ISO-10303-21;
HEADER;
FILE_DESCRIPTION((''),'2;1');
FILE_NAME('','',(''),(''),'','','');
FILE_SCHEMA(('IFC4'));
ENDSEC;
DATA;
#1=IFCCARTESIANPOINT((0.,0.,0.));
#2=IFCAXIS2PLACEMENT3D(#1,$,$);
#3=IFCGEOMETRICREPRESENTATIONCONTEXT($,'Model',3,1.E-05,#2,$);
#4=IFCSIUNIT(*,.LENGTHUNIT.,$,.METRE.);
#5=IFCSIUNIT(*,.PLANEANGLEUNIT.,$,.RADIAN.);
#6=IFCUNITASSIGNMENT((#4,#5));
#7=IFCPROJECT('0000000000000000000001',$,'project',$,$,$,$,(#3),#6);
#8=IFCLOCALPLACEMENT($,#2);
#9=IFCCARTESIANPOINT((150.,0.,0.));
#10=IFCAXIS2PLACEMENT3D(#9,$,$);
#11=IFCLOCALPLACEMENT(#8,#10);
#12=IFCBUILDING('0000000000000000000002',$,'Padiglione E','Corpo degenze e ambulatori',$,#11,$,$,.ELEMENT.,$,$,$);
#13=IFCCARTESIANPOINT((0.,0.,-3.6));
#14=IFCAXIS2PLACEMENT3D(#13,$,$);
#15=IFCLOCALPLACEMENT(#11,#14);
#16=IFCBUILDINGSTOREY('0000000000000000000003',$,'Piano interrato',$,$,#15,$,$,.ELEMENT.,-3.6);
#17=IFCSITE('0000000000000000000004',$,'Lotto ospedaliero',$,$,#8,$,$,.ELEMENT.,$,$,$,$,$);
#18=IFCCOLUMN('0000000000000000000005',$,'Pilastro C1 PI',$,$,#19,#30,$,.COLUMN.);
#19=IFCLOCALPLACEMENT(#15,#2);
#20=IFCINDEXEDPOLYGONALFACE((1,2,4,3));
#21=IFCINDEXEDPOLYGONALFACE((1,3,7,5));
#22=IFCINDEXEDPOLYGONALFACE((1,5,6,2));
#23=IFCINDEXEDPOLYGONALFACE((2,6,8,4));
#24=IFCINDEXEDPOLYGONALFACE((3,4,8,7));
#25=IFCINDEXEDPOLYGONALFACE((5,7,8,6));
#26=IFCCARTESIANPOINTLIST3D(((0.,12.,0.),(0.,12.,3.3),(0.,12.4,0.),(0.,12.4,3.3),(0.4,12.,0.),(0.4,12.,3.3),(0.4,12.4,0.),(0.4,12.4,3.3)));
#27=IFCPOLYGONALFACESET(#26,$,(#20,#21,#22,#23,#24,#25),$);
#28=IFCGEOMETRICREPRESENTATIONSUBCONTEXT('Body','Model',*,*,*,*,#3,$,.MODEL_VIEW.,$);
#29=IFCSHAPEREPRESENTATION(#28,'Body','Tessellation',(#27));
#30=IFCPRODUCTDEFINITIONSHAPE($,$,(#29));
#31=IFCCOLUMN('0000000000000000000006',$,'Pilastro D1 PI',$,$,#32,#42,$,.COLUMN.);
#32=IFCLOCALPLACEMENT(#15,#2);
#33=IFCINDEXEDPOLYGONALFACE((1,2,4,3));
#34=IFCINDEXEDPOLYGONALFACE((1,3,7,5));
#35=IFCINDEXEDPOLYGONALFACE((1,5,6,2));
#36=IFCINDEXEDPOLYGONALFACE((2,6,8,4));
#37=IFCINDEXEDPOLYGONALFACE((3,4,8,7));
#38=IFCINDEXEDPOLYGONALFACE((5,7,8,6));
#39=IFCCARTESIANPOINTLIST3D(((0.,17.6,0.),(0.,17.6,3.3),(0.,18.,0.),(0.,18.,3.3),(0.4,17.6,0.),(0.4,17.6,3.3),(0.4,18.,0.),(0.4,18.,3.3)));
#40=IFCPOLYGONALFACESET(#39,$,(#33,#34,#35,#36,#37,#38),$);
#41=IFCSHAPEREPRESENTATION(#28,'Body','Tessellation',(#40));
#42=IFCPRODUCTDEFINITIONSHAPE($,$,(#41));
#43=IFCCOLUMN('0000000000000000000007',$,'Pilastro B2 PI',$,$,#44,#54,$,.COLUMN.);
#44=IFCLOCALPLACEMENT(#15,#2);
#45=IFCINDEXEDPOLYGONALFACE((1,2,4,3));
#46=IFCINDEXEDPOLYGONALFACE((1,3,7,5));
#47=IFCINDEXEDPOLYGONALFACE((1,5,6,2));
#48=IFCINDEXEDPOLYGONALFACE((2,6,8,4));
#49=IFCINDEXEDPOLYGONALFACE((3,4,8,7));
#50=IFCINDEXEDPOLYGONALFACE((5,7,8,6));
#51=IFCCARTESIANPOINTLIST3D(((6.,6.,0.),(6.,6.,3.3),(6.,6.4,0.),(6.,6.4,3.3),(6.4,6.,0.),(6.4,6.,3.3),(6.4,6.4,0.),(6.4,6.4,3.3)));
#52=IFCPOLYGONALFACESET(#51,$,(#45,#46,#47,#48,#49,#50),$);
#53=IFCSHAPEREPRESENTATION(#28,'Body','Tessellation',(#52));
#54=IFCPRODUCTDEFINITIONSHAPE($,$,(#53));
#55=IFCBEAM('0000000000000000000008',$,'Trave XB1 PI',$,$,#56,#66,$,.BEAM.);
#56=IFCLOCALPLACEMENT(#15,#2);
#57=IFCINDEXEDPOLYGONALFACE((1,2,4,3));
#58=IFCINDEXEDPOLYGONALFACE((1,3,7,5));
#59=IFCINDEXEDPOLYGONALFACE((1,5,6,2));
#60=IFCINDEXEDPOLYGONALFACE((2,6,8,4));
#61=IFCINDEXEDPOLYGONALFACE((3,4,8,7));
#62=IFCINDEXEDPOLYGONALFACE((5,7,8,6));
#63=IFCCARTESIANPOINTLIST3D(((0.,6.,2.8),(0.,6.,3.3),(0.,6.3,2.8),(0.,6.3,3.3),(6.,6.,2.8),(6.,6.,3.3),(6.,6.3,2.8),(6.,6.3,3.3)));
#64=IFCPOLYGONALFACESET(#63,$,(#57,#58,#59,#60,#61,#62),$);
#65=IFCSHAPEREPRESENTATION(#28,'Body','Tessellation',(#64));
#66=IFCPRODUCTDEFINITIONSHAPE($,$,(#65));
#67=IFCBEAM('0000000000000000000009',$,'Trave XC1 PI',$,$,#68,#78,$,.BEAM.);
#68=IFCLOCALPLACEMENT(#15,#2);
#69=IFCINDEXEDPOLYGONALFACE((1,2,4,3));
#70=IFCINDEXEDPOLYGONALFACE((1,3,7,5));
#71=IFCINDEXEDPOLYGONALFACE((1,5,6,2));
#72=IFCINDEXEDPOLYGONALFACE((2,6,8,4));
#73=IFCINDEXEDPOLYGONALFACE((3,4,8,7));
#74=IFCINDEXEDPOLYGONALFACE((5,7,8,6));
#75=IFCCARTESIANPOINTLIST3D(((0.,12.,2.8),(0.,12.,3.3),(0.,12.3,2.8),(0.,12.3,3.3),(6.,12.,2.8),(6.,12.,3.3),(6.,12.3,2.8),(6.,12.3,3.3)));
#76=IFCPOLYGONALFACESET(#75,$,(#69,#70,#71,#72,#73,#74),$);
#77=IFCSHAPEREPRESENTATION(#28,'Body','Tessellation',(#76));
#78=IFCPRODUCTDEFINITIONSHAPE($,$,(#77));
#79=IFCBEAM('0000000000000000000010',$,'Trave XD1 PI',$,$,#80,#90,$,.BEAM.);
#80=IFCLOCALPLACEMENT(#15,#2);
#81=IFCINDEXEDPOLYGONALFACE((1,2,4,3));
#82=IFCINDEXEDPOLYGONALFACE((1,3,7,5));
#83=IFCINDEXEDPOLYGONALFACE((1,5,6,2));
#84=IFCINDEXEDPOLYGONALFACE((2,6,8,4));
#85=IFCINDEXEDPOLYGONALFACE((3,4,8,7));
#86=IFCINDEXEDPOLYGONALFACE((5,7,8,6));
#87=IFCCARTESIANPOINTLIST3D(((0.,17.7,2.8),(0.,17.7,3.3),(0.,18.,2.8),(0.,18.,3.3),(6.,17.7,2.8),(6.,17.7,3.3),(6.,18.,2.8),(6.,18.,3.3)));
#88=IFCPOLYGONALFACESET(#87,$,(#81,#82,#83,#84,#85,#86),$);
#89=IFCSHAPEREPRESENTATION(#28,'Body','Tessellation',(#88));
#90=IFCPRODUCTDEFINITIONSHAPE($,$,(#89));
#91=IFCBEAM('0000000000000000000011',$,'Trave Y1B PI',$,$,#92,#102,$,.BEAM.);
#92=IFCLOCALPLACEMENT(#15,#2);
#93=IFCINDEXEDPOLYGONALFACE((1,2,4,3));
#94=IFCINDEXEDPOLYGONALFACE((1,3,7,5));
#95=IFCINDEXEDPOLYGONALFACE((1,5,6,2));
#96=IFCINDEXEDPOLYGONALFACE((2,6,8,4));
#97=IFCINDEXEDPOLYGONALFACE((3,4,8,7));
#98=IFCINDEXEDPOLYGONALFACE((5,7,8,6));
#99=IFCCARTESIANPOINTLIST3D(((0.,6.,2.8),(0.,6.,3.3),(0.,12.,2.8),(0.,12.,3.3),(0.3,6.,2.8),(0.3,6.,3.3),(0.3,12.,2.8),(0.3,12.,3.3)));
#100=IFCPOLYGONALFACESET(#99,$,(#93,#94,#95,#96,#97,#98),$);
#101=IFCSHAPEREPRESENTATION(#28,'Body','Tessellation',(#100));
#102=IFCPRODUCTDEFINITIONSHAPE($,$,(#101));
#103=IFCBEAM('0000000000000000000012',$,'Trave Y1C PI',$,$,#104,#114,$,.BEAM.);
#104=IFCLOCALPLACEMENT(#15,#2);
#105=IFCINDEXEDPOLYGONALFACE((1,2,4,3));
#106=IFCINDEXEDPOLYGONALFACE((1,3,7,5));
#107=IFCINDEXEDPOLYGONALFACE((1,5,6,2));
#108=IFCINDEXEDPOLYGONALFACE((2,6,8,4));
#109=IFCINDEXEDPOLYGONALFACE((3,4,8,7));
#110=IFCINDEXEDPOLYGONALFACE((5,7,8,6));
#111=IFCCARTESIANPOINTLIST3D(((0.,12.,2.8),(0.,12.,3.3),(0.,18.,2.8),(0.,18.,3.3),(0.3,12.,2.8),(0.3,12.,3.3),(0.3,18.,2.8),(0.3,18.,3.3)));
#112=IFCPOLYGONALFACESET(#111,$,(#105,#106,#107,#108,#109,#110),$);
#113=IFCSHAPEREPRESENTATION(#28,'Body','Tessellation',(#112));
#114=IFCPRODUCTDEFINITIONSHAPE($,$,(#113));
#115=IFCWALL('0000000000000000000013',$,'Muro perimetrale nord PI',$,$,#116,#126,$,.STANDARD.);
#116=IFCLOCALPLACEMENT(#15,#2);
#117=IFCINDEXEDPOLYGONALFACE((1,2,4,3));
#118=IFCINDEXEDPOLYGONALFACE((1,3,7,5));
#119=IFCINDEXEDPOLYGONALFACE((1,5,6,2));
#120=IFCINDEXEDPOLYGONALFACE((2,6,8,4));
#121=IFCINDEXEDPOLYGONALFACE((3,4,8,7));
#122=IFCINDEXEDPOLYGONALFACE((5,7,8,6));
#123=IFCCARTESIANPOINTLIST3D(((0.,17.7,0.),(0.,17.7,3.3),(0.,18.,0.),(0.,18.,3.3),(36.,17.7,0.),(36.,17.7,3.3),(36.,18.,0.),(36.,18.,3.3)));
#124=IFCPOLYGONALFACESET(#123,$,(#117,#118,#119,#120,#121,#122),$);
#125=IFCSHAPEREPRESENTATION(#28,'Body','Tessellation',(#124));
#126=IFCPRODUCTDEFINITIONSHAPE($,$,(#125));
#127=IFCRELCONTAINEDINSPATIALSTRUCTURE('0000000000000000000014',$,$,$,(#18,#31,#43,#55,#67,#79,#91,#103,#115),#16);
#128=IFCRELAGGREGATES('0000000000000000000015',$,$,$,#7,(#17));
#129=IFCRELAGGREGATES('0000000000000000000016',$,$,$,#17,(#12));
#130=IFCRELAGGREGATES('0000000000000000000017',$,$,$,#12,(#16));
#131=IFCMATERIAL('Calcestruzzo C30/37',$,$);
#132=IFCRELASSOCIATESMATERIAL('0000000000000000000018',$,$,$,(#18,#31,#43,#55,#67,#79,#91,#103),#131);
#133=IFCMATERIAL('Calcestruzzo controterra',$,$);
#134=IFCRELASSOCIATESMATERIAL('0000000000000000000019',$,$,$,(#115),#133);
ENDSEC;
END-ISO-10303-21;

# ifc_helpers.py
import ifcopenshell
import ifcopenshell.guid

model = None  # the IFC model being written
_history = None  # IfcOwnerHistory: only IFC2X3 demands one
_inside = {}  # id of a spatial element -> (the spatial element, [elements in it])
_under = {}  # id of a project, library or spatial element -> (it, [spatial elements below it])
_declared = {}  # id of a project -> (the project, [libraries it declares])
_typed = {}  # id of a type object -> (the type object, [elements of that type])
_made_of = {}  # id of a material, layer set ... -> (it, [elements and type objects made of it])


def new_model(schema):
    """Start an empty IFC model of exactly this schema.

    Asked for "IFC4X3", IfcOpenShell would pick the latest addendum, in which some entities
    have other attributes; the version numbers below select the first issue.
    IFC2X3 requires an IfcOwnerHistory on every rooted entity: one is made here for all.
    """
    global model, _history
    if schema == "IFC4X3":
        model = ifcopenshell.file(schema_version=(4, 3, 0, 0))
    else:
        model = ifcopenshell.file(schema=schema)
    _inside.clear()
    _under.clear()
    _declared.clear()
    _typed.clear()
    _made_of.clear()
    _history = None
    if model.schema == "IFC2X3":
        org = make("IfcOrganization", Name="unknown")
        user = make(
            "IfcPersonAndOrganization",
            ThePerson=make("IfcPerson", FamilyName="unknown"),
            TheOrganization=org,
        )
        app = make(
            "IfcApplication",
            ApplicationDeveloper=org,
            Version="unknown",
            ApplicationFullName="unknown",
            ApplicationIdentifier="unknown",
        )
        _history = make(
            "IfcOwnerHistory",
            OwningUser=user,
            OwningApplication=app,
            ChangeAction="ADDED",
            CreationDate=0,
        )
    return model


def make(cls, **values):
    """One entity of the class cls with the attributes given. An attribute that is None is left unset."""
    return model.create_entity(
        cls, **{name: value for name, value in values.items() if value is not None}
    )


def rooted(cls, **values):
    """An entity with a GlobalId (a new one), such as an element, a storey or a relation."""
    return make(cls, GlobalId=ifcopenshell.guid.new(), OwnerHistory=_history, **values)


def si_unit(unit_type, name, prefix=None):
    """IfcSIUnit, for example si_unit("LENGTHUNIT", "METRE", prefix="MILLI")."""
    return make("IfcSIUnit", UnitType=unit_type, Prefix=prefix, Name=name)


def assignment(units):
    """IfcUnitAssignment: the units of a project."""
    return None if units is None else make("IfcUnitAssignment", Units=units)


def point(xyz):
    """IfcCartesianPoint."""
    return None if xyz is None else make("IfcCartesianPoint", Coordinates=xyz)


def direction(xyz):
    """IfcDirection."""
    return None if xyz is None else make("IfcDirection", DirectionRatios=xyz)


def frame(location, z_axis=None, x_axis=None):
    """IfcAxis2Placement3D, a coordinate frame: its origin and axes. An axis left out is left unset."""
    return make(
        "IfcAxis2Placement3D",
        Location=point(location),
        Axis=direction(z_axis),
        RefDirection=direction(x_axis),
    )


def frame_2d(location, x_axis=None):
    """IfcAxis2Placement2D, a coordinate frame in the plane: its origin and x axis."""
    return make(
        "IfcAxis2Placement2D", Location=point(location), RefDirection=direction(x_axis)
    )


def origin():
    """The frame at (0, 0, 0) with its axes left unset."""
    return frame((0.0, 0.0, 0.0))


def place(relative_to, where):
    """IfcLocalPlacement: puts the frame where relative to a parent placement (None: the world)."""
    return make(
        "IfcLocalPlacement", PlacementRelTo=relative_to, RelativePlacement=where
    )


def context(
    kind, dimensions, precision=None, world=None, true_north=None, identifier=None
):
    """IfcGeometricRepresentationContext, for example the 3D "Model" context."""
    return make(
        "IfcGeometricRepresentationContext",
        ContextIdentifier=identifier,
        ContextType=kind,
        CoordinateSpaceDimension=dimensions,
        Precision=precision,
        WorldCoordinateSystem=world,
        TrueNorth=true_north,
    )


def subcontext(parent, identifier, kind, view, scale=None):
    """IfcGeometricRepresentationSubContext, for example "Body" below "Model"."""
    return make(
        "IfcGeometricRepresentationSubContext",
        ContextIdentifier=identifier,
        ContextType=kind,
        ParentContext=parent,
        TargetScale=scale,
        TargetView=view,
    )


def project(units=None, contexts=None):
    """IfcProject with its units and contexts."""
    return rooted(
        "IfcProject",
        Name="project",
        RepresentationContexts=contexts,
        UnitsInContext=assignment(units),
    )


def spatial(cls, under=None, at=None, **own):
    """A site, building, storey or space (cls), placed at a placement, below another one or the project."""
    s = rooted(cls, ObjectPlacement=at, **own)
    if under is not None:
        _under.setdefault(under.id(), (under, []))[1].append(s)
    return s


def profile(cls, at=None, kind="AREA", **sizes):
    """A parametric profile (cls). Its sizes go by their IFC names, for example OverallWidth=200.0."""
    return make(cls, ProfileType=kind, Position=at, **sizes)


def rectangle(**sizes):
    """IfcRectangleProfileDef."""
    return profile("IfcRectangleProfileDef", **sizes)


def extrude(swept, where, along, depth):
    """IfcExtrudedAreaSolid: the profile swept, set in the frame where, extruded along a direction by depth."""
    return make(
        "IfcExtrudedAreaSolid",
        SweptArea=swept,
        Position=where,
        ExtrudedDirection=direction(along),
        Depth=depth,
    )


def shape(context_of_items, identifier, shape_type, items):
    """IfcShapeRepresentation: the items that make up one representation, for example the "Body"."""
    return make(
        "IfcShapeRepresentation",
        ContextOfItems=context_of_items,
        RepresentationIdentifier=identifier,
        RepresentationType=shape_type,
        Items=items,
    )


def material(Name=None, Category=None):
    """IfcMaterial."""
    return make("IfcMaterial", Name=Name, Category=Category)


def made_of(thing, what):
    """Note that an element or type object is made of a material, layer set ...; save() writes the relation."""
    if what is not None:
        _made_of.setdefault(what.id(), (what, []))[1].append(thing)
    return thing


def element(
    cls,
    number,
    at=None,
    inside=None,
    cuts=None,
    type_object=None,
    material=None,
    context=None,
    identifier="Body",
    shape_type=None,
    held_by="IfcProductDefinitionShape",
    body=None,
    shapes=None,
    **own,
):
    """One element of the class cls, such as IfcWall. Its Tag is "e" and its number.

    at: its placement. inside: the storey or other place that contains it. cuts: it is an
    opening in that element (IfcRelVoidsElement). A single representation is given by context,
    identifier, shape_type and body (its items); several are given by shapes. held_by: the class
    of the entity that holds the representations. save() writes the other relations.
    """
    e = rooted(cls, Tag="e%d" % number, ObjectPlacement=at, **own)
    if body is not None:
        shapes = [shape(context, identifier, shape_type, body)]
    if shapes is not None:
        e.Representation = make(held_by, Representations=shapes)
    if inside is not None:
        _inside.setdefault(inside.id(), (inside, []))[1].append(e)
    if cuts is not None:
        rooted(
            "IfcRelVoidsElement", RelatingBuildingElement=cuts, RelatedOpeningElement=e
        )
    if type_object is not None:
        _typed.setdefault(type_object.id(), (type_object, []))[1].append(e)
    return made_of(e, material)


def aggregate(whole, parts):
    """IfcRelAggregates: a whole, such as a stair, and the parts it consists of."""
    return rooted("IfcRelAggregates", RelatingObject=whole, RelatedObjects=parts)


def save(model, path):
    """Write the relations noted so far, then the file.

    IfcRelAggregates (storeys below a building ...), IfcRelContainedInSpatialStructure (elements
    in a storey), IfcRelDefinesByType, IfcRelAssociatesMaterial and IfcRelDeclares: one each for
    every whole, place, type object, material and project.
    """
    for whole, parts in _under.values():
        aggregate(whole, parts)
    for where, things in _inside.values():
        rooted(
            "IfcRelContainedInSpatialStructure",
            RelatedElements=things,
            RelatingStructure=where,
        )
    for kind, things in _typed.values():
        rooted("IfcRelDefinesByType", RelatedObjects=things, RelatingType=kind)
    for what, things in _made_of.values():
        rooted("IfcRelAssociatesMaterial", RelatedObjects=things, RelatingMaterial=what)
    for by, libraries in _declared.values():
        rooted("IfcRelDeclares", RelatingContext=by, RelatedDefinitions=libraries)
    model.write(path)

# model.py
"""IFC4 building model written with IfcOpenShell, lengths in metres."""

from ifc_helpers import new_model, si_unit, frame, frame_2d, origin, place, context, subcontext, project, spatial, rectangle, extrude, material, element, save


model = new_model("IFC4")

# Units and contexts
model_context = context("Model", 3, precision=1e-05, world=origin())
body_context = subcontext(model_context, "Body", "Model", "MODEL_VIEW")
ifc_project = project(units=[si_unit("LENGTHUNIT", "METRE"), si_unit("PLANEANGLEUNIT", "RADIAN")], contexts=[model_context])

# Site, building, storey
site_placement = place(None, origin())
site = spatial("IfcSite", under=ifc_project, at=site_placement, Name="Lotto ospedaliero", CompositionType="ELEMENT")
building_placement = place(site_placement, frame((150.0, 0.0, 0.0)))
building = spatial("IfcBuilding", under=site, at=building_placement, Name="Padiglione E", Description="Corpo degenze e ambulatori", CompositionType="ELEMENT")
storey_placement = place(building_placement, frame((0.0, 0.0, -3.6)))
storey = spatial("IfcBuildingStorey", under=building, at=storey_placement, Name="Piano interrato", CompositionType="ELEMENT", Elevation=-3.6)

# Columns
ifc_material_1 = material(Name="Calcestruzzo C30/37")
for number, where, name in (
    (1, (0.0, 12.0, 0.0), "Pilastro C1 PI"),
    (2, (0.0, 17.6, 0.0), "Pilastro D1 PI"),
    (3, (6.0, 6.0, 0.0), "Pilastro B2 PI"),
):
    element("IfcColumn", number, at=place(storey_placement, frame(where)), inside=storey, material=ifc_material_1, Name=name, PredefinedType="COLUMN", context=body_context, shape_type="SweptSolid", body=[
        extrude(rectangle(XDim=0.4, YDim=0.4, at=frame_2d((0.2, 0.2))), origin(), (0.0, 0.0, 1.0), 3.3),
    ])

# Beams
for number, where, name in (
    (4, (0.0, 6.0, 2.8), "Trave XB1 PI"),
    (5, (0.0, 12.0, 2.8), "Trave XC1 PI"),
    (6, (0.0, 17.7, 2.8), "Trave XD1 PI"),
):
    element("IfcBeam", number, at=place(storey_placement, frame(where)), inside=storey, material=ifc_material_1, Name=name, PredefinedType="BEAM", context=body_context, shape_type="SweptSolid", body=[
        extrude(rectangle(XDim=6.0, YDim=0.3, at=frame_2d((3.0, 0.15))), origin(), (0.0, 0.0, 1.0), 0.5),
    ])
for number, where, name in (
    (7, (0.0, 6.0, 2.8), "Trave Y1B PI"),
    (8, (0.0, 12.0, 2.8), "Trave Y1C PI"),
):
    element("IfcBeam", number, at=place(storey_placement, frame(where)), inside=storey, material=ifc_material_1, Name=name, PredefinedType="BEAM", context=body_context, shape_type="SweptSolid", body=[
        extrude(rectangle(XDim=0.3, YDim=6.0, at=frame_2d((0.15, 3.0))), origin(), (0.0, 0.0, 1.0), 0.5),
    ])

# Wall
ifc_material_2 = material(Name="Calcestruzzo controterra")
wall_1_placement = place(storey_placement, frame((0.0, 17.7, 0.0)))
element("IfcWall", 9, at=wall_1_placement, inside=storey, material=ifc_material_2, Name="Muro perimetrale nord PI", PredefinedType="STANDARD", context=body_context, shape_type="SweptSolid", body=[
    extrude(rectangle(XDim=36.0, YDim=0.3, at=frame_2d((18.0, 0.15))), origin(), (0.0, 0.0, 1.0), 3.3),
])

save(model, "model.ifc")
